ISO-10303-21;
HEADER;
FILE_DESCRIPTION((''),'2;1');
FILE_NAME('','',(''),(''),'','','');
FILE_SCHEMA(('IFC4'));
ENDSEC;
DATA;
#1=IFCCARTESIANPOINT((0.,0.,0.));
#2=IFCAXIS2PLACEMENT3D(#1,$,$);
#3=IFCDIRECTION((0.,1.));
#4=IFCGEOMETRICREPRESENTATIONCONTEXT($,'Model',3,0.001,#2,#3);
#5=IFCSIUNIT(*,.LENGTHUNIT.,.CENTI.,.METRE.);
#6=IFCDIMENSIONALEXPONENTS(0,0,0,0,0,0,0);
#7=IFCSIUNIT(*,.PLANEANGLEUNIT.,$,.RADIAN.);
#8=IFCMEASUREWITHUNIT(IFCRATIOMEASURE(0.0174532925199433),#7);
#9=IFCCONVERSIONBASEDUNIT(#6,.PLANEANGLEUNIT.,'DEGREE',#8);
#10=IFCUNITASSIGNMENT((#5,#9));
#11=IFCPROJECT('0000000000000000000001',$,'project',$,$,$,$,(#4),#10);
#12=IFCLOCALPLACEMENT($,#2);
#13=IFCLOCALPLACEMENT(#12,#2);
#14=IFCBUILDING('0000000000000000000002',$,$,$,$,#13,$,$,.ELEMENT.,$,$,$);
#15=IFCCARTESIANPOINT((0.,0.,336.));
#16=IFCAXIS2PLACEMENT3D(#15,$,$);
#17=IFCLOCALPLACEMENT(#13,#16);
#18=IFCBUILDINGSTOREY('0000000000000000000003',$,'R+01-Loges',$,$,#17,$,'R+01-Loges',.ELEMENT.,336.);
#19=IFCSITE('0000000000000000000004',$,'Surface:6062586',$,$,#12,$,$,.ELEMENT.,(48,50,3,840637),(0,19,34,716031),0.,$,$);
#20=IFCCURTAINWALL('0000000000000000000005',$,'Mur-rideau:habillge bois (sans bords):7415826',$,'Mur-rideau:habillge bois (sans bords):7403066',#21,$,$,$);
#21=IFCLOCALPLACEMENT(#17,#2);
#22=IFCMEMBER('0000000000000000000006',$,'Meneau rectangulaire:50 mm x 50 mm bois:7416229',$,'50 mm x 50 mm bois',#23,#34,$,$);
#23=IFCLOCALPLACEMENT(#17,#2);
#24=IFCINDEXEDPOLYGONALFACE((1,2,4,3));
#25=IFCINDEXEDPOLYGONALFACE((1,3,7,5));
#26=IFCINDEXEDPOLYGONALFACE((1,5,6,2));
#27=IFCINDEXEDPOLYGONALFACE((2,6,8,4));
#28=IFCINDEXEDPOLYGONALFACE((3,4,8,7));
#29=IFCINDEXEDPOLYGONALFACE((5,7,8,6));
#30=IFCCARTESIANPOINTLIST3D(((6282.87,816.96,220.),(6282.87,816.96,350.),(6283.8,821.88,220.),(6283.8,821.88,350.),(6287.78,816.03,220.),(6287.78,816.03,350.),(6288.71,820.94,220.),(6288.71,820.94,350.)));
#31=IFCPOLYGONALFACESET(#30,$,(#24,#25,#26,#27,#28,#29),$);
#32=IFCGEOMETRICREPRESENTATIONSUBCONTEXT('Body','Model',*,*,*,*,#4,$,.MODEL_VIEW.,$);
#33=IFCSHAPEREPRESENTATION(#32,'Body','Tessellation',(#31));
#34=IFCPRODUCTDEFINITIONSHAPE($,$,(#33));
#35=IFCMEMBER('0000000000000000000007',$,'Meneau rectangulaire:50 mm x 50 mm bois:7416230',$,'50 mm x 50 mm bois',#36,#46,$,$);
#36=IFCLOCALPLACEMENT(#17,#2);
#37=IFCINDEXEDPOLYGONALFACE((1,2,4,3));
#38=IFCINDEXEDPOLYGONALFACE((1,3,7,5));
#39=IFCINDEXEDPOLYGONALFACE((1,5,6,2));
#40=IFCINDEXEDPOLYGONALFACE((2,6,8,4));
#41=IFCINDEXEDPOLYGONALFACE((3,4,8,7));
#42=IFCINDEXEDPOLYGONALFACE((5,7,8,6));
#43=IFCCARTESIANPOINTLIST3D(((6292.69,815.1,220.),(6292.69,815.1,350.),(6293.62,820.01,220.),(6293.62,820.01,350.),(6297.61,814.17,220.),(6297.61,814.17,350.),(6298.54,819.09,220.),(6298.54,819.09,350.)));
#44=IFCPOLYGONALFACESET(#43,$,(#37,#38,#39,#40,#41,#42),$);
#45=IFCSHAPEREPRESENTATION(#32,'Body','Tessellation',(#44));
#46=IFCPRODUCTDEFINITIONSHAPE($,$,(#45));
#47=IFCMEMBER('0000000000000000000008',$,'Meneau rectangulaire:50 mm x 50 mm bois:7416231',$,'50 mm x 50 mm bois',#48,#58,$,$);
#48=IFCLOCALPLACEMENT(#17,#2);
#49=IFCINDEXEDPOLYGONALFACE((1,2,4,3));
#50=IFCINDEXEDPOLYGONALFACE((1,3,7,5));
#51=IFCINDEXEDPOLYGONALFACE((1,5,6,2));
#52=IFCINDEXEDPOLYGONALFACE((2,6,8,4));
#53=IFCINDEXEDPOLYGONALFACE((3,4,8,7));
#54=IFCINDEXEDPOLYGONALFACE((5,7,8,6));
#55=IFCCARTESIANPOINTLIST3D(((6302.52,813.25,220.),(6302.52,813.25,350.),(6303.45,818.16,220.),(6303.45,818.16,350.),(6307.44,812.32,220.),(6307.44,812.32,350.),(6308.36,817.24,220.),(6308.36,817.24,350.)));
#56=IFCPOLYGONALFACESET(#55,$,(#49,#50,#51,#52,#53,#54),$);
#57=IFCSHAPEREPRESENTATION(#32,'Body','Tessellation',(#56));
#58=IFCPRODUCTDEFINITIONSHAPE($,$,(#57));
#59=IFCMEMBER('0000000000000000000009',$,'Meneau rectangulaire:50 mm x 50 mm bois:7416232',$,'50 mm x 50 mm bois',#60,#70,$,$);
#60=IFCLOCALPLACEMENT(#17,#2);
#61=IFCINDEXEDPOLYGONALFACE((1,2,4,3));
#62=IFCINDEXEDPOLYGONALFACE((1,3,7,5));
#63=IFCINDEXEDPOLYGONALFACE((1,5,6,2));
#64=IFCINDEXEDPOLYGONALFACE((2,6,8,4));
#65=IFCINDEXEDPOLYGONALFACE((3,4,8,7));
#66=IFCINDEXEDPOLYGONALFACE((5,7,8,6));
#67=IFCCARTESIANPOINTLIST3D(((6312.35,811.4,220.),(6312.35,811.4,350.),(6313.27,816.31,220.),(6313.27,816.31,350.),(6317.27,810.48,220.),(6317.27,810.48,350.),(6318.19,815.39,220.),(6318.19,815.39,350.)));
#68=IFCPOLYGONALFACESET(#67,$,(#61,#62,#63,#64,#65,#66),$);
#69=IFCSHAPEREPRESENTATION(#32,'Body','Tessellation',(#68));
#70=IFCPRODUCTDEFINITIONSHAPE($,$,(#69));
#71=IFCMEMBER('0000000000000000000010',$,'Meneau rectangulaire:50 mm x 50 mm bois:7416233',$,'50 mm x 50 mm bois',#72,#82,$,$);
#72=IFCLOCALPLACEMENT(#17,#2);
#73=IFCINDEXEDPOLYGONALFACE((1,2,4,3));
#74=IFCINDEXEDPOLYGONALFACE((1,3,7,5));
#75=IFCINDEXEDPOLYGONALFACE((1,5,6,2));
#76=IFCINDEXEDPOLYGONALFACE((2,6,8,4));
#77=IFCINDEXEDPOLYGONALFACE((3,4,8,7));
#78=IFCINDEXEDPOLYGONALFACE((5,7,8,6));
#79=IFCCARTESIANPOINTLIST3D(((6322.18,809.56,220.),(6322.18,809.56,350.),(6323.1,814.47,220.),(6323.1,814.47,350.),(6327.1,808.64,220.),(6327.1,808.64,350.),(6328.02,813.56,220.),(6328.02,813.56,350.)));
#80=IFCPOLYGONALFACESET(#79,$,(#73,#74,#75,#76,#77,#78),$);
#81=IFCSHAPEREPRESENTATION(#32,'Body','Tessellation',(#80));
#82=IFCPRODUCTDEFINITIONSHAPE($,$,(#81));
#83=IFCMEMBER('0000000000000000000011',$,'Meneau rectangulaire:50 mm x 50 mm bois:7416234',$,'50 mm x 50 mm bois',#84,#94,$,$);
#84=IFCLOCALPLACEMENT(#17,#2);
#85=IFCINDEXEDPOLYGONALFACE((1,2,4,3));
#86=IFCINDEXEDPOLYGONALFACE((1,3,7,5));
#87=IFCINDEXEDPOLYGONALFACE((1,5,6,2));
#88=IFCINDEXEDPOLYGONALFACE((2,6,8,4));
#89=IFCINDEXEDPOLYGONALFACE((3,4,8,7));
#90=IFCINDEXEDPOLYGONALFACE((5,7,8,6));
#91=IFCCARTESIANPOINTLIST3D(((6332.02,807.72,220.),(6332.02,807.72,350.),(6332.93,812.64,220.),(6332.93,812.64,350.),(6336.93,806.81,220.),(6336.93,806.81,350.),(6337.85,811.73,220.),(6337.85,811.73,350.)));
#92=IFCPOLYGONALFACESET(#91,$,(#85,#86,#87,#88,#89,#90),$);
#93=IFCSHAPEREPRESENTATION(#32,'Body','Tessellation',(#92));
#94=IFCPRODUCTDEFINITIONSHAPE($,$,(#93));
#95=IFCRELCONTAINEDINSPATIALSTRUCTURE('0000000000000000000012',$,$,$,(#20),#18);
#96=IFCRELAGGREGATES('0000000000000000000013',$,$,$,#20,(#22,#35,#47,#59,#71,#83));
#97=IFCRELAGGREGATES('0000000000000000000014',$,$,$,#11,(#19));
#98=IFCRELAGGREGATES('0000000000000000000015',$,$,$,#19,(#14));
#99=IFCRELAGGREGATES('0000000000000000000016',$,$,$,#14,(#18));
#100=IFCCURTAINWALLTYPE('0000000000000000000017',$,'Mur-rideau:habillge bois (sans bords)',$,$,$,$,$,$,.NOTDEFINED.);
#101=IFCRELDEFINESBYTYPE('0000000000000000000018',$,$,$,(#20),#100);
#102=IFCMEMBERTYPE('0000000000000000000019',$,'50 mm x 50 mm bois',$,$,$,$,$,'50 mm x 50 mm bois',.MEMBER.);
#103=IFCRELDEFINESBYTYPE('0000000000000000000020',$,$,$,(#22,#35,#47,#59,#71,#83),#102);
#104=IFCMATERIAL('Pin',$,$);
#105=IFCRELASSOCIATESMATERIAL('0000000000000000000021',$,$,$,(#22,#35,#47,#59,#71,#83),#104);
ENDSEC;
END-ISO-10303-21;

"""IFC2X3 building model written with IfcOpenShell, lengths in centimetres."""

from ifc_helpers import new_model, entity, si_unit, converted_unit, direction, frame, origin, origin_2d_with_axis, place, context, subcontext, project, spatial, rectangle, extrude, source, transform, mapped, material, type_object, type_shapes, element, aggregate, save


model = new_model("IFC2X3")

# Units and contexts
model_context = context("Model", 3, precision=0.001, world=origin(), true_north=direction((0.0, 1.0)))
body_context = subcontext(model_context, "Body", "Model", "MODEL_VIEW")
ifc_project = project(units=[si_unit("LENGTHUNIT", "METRE", prefix="CENTI"), converted_unit("PLANEANGLEUNIT", "DEGREE", entity("IfcRatioMeasure", 0.0174532925199433), si_unit("PLANEANGLEUNIT", "RADIAN"), dimensions=[0, 0, 0, 0, 0, 0, 0])], contexts=[model_context])

# Site, building, storey
site_placement = place(None, origin())
site = spatial("IfcSite", under=ifc_project, at=site_placement, Name="Surface:6062586", CompositionType="ELEMENT", RefLatitude=(48, 50, 3, 840637), RefLongitude=(0, 19, 34, 716031), RefElevation=0.0)
building_placement = place(site_placement, origin())
building = spatial("IfcBuilding", under=site, at=building_placement, CompositionType="ELEMENT")
storey_placement = place(building_placement, frame((0.0, 0.0, 336.0)))
storey = spatial("IfcBuildingStorey", under=building, at=storey_placement, Name="R+01-Loges", LongName="R+01-Loges", CompositionType="ELEMENT", Elevation=336.0)

# Curtain wall, members
curtain_wall_type = type_object("IfcCurtainWallType", Name="Mur-rideau:habillge bois (sans bords)", PredefinedType="NOTDEFINED")
curtain_wall_placement = place(storey_placement, frame((0.0, 0.0, -336.0)))
curtain_wall = element("IfcCurtainWall", 1, at=curtain_wall_placement, inside=storey, type_object=curtain_wall_type, Name="Mur-rideau:habillge bois (sans bords):7415826", ObjectType="Mur-rideau:habillge bois (sans bords):7403066")
ifc_material = material(Name="Pin")
member_type = type_object("IfcMemberType", Name="50 mm x 50 mm bois", ElementType="50 mm x 50 mm bois", PredefinedType="MEMBER")
shared_shape = source(origin(), body_context, "Body", "SweptSolid", [
    extrude(rectangle(XDim=5.0, YDim=5.0, at=origin_2d_with_axis()), frame((0.0, 0.0, -130.0), z_axis=(0.0, 0.0, 1.0), x_axis=(0.0, -1.0, 0.0)), (0.0, 0.0, 1.0), 130.0),
])
type_shapes(member_type, [shared_shape])
member_1_placement = place(storey_placement, frame((6285.79, 818.95, 220.0), z_axis=(0.0, 0.0, -1.0), x_axis=(0.982477, -0.186382, 0.0)))
member_1 = element("IfcMember", 2, at=member_1_placement, type_object=member_type, material=ifc_material, Name="Meneau rectangulaire:50 mm x 50 mm bois:7416229", ObjectType="50 mm x 50 mm bois", context=body_context, shape_type="MappedRepresentation", body=[
    mapped(shared_shape, transform((0.0, 0.0, 0.0), scale=1.0)),
])
member_2_placement = place(storey_placement, frame((6295.62, 817.09, 220.0), z_axis=(0.0, 0.0, -1.0), x_axis=(0.982614, -0.185659, 0.0)))
member_2 = element("IfcMember", 3, at=member_2_placement, type_object=member_type, material=ifc_material, Name="Meneau rectangulaire:50 mm x 50 mm bois:7416230", ObjectType="50 mm x 50 mm bois", context=body_context, shape_type="MappedRepresentation", body=[
    mapped(shared_shape, transform((0.0, 0.0, 0.0), scale=1.0)),
])
member_3_placement = place(storey_placement, frame((6305.44, 815.24, 220.0), z_axis=(0.0, 0.0, -1.0), x_axis=(0.982751, -0.184936, 0.0)))
member_3 = element("IfcMember", 4, at=member_3_placement, type_object=member_type, material=ifc_material, Name="Meneau rectangulaire:50 mm x 50 mm bois:7416231", ObjectType="50 mm x 50 mm bois", context=body_context, shape_type="MappedRepresentation", body=[
    mapped(shared_shape, transform((0.0, 0.0, 0.0), scale=1.0)),
])
member_4_placement = place(storey_placement, frame((6315.27, 813.4, 220.0), z_axis=(0.0, 0.0, -1.0), x_axis=(0.982886, -0.184213, 0.0)))
member_4 = element("IfcMember", 5, at=member_4_placement, type_object=member_type, material=ifc_material, Name="Meneau rectangulaire:50 mm x 50 mm bois:7416232", ObjectType="50 mm x 50 mm bois", context=body_context, shape_type="MappedRepresentation", body=[
    mapped(shared_shape, transform((0.0, 0.0, 0.0), scale=1.0)),
])
member_5_placement = place(storey_placement, frame((6325.1, 811.56, 220.0), z_axis=(0.0, 0.0, -1.0), x_axis=(0.983022, -0.18349, 0.0)))
member_5 = element("IfcMember", 6, at=member_5_placement, type_object=member_type, material=ifc_material, Name="Meneau rectangulaire:50 mm x 50 mm bois:7416233", ObjectType="50 mm x 50 mm bois", context=body_context, shape_type="MappedRepresentation", body=[
    mapped(shared_shape, transform((0.0, 0.0, 0.0), scale=1.0)),
])
member_6_placement = place(storey_placement, frame((6334.93, 809.73, 220.0), z_axis=(0.0, 0.0, -1.0), x_axis=(0.983156, -0.182766, 0.0)))
member_6 = element("IfcMember", 7, at=member_6_placement, type_object=member_type, material=ifc_material, Name="Meneau rectangulaire:50 mm x 50 mm bois:7416234", ObjectType="50 mm x 50 mm bois", context=body_context, shape_type="MappedRepresentation", body=[
    mapped(shared_shape, transform((0.0, 0.0, 0.0), scale=1.0)),
])
aggregate(curtain_wall, [member_1, member_2, member_3, member_4, member_5, member_6])

save(model, "model.ifc")
